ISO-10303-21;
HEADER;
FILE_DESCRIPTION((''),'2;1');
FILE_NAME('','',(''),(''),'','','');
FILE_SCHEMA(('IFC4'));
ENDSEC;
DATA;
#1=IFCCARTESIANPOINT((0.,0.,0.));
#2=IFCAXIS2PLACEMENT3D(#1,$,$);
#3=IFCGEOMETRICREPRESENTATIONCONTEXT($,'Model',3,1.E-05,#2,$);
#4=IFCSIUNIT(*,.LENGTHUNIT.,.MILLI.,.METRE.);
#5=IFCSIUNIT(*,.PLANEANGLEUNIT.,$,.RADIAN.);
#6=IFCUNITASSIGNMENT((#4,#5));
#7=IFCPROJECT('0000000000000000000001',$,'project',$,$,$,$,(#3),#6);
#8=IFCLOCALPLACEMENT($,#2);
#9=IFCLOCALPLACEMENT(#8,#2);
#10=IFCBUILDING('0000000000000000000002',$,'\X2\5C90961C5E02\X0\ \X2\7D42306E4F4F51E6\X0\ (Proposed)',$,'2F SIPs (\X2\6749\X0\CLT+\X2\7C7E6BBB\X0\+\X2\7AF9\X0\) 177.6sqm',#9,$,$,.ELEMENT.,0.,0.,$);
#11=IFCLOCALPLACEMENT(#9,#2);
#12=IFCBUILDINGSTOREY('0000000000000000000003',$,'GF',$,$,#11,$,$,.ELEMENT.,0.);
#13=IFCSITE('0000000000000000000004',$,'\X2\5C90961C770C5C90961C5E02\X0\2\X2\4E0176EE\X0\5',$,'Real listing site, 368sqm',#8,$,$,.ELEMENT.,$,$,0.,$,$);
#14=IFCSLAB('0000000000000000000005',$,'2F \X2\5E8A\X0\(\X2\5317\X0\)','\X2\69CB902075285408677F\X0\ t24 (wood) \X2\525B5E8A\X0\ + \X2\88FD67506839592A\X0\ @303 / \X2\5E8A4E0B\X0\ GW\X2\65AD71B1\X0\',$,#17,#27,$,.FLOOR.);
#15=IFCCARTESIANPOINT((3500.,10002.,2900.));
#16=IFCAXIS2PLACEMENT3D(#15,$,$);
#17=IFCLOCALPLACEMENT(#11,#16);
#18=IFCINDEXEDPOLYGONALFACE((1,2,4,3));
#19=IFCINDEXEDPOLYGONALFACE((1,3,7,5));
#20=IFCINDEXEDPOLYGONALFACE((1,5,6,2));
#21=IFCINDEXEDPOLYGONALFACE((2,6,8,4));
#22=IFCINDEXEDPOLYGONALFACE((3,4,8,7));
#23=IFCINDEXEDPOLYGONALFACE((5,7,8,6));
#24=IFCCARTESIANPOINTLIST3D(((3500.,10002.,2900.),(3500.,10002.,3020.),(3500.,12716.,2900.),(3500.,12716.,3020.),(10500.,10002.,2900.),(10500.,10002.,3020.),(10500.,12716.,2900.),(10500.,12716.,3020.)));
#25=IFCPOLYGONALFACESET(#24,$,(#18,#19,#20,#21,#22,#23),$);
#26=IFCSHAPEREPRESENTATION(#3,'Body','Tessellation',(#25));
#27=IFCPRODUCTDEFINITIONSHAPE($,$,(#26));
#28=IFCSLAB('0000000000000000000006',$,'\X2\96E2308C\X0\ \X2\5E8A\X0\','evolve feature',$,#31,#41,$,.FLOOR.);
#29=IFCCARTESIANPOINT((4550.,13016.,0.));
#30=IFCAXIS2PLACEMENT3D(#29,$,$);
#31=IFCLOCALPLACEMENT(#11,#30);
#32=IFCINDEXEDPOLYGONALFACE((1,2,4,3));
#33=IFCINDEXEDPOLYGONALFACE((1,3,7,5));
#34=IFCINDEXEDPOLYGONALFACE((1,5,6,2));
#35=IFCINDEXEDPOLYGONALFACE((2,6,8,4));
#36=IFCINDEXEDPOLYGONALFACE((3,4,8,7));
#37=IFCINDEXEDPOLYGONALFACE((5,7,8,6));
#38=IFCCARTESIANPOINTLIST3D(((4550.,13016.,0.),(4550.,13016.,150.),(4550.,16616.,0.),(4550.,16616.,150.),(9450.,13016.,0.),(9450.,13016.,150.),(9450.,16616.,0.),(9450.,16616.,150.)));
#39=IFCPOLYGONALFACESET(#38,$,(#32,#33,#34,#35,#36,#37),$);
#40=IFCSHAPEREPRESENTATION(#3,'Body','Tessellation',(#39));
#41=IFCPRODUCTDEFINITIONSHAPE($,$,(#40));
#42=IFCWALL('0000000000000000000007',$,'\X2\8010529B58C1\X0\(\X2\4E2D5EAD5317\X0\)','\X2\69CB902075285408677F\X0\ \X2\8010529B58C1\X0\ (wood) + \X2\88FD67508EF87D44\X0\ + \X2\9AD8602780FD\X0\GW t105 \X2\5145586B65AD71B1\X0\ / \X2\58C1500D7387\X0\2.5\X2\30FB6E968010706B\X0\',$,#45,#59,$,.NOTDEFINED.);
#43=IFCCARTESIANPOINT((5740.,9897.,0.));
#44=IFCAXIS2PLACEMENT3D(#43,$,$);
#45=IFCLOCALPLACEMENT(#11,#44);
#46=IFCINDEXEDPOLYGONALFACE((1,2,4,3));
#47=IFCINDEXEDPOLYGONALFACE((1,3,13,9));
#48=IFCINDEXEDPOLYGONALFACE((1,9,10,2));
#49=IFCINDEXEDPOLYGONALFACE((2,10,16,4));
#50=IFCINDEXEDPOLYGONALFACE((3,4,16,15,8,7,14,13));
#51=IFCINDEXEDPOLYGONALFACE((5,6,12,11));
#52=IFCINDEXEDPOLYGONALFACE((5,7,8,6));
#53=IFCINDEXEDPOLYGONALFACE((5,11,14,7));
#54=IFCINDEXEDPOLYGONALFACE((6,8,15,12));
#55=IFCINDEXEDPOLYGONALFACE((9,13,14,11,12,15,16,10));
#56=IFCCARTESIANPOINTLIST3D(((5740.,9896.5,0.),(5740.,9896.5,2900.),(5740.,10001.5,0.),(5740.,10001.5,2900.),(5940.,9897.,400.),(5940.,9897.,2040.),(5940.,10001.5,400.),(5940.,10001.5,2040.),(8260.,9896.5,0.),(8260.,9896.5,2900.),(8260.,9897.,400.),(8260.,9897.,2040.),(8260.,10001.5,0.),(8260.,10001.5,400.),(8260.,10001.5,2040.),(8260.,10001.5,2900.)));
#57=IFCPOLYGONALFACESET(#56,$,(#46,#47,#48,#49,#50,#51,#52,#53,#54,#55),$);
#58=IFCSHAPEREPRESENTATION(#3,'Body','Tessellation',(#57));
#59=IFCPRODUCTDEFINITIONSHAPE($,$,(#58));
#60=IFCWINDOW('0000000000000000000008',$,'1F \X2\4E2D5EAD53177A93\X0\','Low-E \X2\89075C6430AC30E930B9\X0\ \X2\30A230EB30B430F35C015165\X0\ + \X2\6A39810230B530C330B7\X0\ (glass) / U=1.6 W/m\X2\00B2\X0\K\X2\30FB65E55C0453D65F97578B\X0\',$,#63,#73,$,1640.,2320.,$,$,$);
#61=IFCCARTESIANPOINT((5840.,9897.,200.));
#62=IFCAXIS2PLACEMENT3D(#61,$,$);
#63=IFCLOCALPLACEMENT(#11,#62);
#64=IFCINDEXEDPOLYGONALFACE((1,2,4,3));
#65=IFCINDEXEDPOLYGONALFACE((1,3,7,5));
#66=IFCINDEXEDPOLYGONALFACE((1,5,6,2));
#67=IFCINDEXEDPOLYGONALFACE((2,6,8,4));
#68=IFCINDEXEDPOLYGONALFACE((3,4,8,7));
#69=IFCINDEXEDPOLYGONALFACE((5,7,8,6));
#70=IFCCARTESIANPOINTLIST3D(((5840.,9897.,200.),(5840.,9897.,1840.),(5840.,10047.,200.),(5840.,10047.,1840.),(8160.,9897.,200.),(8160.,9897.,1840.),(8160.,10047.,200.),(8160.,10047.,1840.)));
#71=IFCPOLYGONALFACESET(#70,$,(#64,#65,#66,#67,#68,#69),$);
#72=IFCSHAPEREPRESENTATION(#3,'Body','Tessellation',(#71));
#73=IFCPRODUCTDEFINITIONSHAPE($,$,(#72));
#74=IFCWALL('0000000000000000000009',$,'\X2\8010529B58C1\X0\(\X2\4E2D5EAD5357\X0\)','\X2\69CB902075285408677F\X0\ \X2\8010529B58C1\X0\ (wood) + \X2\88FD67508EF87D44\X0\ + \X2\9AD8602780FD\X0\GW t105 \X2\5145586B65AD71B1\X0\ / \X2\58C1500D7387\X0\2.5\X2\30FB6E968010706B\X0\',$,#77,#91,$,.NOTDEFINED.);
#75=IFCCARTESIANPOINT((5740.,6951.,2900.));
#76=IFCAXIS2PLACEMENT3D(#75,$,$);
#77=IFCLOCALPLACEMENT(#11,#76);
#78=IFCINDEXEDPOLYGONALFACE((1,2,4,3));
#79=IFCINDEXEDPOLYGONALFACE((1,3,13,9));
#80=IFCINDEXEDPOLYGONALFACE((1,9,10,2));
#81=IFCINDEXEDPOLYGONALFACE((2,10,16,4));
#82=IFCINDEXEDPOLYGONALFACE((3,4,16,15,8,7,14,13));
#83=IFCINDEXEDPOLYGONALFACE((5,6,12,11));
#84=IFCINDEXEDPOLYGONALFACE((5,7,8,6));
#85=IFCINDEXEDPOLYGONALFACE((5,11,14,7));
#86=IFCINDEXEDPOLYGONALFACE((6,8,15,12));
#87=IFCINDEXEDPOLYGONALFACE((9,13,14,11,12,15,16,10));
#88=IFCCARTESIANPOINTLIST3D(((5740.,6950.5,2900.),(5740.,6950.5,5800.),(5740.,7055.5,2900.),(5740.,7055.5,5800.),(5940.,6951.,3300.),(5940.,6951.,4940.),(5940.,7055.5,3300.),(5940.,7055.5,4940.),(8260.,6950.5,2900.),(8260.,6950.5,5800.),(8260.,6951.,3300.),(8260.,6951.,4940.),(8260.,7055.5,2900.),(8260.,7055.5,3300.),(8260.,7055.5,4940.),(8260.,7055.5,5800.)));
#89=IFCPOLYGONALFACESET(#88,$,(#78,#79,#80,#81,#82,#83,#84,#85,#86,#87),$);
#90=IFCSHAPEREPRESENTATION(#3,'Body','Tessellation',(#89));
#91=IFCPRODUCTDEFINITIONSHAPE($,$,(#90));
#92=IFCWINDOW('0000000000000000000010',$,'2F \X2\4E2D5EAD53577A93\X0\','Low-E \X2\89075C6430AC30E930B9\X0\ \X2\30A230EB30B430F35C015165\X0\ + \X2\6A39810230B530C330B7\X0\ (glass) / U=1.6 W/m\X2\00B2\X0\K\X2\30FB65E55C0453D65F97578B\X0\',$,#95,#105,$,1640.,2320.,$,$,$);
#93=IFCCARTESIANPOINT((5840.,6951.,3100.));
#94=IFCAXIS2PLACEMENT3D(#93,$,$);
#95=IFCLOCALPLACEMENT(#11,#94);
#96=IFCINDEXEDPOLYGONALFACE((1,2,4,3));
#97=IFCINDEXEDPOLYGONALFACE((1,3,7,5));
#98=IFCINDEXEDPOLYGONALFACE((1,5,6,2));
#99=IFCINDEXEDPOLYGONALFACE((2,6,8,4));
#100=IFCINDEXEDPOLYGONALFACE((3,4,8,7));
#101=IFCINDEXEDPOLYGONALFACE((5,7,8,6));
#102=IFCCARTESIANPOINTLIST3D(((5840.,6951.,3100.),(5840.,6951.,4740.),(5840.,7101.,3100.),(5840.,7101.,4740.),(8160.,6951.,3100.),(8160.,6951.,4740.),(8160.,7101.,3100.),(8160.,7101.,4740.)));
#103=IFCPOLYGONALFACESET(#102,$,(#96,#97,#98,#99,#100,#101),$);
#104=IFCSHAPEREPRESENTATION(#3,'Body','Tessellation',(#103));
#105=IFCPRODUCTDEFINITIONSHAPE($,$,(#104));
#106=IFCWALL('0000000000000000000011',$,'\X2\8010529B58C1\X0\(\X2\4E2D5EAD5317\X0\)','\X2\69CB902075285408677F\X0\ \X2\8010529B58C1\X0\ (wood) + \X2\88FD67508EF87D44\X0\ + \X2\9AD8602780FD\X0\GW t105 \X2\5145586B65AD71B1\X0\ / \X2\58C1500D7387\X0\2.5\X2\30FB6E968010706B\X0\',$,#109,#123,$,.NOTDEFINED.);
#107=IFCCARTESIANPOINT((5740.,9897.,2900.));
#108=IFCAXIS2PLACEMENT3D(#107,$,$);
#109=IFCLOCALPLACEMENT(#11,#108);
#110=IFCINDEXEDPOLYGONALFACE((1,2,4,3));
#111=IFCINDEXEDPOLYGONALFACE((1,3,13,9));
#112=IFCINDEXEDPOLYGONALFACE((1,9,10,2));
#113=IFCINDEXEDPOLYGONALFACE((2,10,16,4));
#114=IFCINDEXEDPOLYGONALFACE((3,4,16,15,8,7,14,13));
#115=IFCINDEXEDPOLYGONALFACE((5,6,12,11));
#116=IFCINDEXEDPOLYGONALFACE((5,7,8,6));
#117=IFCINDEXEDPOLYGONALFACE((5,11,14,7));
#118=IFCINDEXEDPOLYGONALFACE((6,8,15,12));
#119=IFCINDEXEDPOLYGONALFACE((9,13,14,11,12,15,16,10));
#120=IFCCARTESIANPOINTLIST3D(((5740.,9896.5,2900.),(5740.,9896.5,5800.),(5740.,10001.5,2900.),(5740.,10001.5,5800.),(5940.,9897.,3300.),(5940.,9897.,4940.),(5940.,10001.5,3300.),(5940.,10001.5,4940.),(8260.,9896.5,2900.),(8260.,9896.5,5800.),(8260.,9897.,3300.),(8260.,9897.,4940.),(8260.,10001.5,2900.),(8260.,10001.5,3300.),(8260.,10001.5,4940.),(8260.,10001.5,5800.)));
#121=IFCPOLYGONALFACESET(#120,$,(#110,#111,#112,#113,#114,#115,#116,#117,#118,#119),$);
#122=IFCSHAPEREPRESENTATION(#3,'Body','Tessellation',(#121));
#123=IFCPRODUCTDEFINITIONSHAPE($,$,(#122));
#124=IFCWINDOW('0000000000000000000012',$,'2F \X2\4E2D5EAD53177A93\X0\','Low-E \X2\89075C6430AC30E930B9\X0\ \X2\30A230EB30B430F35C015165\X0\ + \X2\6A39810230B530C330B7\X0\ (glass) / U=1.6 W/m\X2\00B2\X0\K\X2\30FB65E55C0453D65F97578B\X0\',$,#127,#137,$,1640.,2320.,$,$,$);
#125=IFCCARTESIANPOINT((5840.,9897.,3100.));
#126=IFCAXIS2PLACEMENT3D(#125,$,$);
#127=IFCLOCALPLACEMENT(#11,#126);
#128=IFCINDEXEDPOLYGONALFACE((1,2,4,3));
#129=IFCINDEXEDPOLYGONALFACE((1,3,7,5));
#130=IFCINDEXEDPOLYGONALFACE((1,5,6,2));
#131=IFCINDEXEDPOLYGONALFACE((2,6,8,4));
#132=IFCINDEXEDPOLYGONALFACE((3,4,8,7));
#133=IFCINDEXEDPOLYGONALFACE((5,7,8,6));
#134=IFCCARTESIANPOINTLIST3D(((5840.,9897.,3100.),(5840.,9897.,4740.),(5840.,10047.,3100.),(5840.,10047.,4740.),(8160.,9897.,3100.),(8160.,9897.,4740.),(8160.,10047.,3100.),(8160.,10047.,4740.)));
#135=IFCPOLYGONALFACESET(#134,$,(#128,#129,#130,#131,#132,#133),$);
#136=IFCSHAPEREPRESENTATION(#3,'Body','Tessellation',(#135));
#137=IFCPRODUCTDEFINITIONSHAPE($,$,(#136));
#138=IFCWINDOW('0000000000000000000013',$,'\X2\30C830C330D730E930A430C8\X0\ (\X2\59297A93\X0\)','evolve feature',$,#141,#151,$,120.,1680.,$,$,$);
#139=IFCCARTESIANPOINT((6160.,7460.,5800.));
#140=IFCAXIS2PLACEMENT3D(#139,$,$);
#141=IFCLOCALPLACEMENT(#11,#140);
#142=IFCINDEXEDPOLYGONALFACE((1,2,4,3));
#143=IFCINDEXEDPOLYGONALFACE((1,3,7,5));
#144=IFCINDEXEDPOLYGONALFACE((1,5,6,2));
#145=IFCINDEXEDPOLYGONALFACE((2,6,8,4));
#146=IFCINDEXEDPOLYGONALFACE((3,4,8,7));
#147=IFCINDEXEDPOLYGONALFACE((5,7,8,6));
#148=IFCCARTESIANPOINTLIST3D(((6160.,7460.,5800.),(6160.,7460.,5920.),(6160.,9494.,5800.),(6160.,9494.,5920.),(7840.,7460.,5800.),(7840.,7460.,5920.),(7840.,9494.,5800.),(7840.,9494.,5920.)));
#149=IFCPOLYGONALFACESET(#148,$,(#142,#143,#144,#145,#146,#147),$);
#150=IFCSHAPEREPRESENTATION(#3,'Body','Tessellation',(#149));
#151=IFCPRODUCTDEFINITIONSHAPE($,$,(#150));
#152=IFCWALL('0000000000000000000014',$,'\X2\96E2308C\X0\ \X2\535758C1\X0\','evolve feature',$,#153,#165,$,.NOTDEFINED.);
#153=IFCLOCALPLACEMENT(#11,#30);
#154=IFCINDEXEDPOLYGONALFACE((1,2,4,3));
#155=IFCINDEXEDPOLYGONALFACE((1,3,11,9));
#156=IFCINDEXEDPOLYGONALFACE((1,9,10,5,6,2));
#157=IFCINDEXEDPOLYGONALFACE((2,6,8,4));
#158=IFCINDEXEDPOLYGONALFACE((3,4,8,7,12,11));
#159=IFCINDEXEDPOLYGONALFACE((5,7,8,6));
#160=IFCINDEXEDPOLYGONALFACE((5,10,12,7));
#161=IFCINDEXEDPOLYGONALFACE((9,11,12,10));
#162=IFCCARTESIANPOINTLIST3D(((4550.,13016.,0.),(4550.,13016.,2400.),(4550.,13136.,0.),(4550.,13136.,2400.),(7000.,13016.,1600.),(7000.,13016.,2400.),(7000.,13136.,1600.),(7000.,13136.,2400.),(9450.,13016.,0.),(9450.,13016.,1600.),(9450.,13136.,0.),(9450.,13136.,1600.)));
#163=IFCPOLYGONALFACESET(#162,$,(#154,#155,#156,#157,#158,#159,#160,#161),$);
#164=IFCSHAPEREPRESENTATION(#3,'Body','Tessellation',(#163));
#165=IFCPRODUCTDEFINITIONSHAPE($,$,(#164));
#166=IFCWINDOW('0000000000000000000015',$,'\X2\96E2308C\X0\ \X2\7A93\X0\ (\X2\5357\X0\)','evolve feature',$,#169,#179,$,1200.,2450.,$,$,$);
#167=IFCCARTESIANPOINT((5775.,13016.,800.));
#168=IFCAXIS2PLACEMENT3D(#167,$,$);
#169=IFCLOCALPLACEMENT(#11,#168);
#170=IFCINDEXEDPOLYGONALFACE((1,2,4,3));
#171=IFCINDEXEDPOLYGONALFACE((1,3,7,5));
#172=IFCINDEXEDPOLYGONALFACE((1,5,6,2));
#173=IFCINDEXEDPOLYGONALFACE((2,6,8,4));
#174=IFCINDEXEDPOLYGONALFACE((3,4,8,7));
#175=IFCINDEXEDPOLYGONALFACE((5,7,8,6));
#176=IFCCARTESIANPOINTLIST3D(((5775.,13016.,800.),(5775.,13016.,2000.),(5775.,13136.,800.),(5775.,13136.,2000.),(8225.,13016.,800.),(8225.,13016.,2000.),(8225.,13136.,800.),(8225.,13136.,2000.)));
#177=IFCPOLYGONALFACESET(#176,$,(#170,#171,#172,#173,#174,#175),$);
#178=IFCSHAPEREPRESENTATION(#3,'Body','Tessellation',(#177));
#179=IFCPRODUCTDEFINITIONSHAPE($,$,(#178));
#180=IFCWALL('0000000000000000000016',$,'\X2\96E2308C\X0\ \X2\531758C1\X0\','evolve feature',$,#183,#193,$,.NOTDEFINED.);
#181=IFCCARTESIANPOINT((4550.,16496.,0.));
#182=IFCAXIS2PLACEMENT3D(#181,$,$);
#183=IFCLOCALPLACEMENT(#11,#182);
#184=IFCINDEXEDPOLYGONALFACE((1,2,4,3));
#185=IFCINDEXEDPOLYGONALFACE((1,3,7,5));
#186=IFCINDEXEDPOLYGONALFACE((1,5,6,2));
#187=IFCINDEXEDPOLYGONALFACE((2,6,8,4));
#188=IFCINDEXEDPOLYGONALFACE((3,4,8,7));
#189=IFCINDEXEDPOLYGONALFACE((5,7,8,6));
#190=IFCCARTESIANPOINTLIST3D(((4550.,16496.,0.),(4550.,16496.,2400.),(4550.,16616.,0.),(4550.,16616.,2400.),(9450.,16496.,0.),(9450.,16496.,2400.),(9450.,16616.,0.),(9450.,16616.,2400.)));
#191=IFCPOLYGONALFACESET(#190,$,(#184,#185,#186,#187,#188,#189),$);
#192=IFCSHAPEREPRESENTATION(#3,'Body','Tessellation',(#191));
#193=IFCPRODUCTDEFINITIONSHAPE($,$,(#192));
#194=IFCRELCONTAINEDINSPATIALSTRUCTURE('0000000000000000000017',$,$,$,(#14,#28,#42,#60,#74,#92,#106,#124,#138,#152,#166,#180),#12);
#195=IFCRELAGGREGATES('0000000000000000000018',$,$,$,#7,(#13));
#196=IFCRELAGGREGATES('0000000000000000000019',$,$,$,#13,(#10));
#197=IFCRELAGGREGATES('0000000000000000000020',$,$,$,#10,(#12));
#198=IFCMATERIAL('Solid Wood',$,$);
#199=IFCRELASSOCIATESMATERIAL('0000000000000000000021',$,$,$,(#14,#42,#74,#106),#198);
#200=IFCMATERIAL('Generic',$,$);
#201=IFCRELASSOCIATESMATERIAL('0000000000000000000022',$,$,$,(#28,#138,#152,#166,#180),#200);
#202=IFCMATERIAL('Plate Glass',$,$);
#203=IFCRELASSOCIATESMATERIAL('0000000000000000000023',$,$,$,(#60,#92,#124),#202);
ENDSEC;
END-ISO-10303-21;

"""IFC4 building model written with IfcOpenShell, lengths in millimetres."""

from ifc_helpers import new_model, si_unit, frame, frame_2d, origin, place, context, project, spatial, rectangle, extrude, material, element, fill, save


model = new_model("IFC4")

# Units and contexts
model_context = context("Model", 3, precision=1e-05, world=origin())
ifc_project = project(units=[si_unit("LENGTHUNIT", "METRE", prefix="MILLI"), si_unit("PLANEANGLEUNIT", "RADIAN")], contexts=[model_context])

# Site, building, storey
site_placement = place(None, origin())
site = spatial("IfcSite", under=ifc_project, at=site_placement, Name="岐阜県岐阜市2丁目5", ObjectType="Real listing site, 368sqm", CompositionType="ELEMENT", RefElevation=0.0)
building_placement = place(site_placement, origin())
building = spatial("IfcBuilding", under=site, at=building_placement, Name="岐阜市 終の住処 (Proposed)", ObjectType="2F SIPs (杉CLT+籾殻+竹) 177.6sqm", CompositionType="ELEMENT", ElevationOfRefHeight=0.0, ElevationOfTerrain=0.0)
storey_placement = place(building_placement, origin())
storey = spatial("IfcBuildingStorey", under=building, at=storey_placement, Name="GF", CompositionType="ELEMENT", Elevation=0.0)

# Slabs
ifc_material_1 = material(Name="Solid Wood")
slab_1_placement = place(storey_placement, frame((3500.0, 10002.0, 2900.0)))
element("IfcSlab", 1, at=slab_1_placement, inside=storey, material=ifc_material_1, Name="2F 床(北)", Description="構造用合板 t24 (wood) 剛床 + 製材根太 @303 / 床下 GW断熱", PredefinedType="FLOOR", context=model_context, shape_type="SweptSolid", body=[
    extrude(rectangle(XDim=7000.0, YDim=2714.0, at=frame_2d((3500.0, 1357.0))), frame((3500.0, 10002.0, 2900.0)), (0.0, 0.0, 1.0), 120.0),
])
ifc_material_2 = material(Name="Generic")
slab_2_placement = place(storey_placement, frame((4550.0, 13016.0, 0.0)))
element("IfcSlab", 2, at=slab_2_placement, inside=storey, material=ifc_material_2, Name="離れ 床", Description="evolve feature", PredefinedType="FLOOR", context=model_context, shape_type="SweptSolid", body=[
    extrude(rectangle(XDim=4900.0, YDim=3600.0, at=frame_2d((2450.0, 1800.0))), frame((4550.0, 13016.0, 0.0)), (0.0, 0.0, 1.0), 150.0),
])

# Wall, opening, window
wall_1_placement = place(storey_placement, frame((5740.0, 9897.0, 0.0)))
wall_1 = element("IfcWall", 3, at=wall_1_placement, inside=storey, material=ifc_material_1, Name="耐力壁(中庭北)", Description="構造用合板 耐力壁 (wood) + 製材軸組 + 高性能GW t105 充填断熱 / 壁倍率2.5・準耐火", PredefinedType="NOTDEFINED", context=model_context, shape_type="SweptSolid", body=[
    extrude(rectangle(XDim=2520.0, YDim=105.0, at=frame_2d((1260.0, 52.0))), frame((5740.0, 9897.0, 0.0)), (0.0, 0.0, 1.0), 2900.0),
])
opening_1_placement = place(storey_placement, frame((5840.0, 9897.0, 200.0)))
opening_1 = element("IfcOpeningElement", 4, at=opening_1_placement, cuts=wall_1, PredefinedType="NOTDEFINED", context=model_context, shape_type="SweptSolid", body=[
    extrude(rectangle(XDim=2320.0, YDim=150.0, at=frame_2d((1160.0, 75.0))), frame((5840.0, 9897.0, 200.0)), (0.0, 0.0, 1.0), 1640.0),
])
ifc_material_3 = material(Name="Plate Glass")
window_1_placement = place(storey_placement, frame((5840.0, 9897.0, 200.0)))
window_1 = element("IfcWindow", 5, at=window_1_placement, inside=storey, material=ifc_material_3, Name="1F 中庭北窓", Description="Low-E 複層ガラス アルゴン封入 + 樹脂サッシ (glass) / U=1.6 W/m²K・日射取得型", OverallHeight=1640.0, OverallWidth=2320.0, context=model_context, shape_type="SweptSolid", body=[
    extrude(rectangle(XDim=2320.0, YDim=150.0, at=frame_2d((1160.0, 75.0))), frame((5840.0, 9897.0, 200.0)), (0.0, 0.0, 1.0), 1640.0),
])
fill(opening_1, window_1)

# Walls, openings, windows
wall_2_placement = place(storey_placement, frame((5740.0, 6951.0, 2900.0)))
wall_2 = element("IfcWall", 6, at=wall_2_placement, inside=storey, material=ifc_material_1, Name="耐力壁(中庭南)", Description="構造用合板 耐力壁 (wood) + 製材軸組 + 高性能GW t105 充填断熱 / 壁倍率2.5・準耐火", PredefinedType="NOTDEFINED", context=model_context, shape_type="SweptSolid", body=[
    extrude(rectangle(XDim=2520.0, YDim=105.0, at=frame_2d((1260.0, 52.0))), frame((5740.0, 6951.0, 2900.0)), (0.0, 0.0, 1.0), 2900.0),
])
opening_2_placement = place(storey_placement, frame((5840.0, 6951.0, 3100.0)))
opening_2 = element("IfcOpeningElement", 7, at=opening_2_placement, cuts=wall_2, PredefinedType="NOTDEFINED", context=model_context, shape_type="SweptSolid", body=[
    extrude(rectangle(XDim=2320.0, YDim=150.0, at=frame_2d((1160.0, 75.0))), frame((5840.0, 6951.0, 3100.0)), (0.0, 0.0, 1.0), 1640.0),
])
window_2_placement = place(storey_placement, frame((5840.0, 6951.0, 3100.0)))
window_2 = element("IfcWindow", 8, at=window_2_placement, inside=storey, material=ifc_material_3, Name="2F 中庭南窓", Description="Low-E 複層ガラス アルゴン封入 + 樹脂サッシ (glass) / U=1.6 W/m²K・日射取得型", OverallHeight=1640.0, OverallWidth=2320.0, context=model_context, shape_type="SweptSolid", body=[
    extrude(rectangle(XDim=2320.0, YDim=150.0, at=frame_2d((1160.0, 75.0))), frame((5840.0, 6951.0, 3100.0)), (0.0, 0.0, 1.0), 1640.0),
])
fill(opening_2, window_2)
wall_3_placement = place(storey_placement, frame((5740.0, 9897.0, 2900.0)))
wall_3 = element("IfcWall", 9, at=wall_3_placement, inside=storey, material=ifc_material_1, Name="耐力壁(中庭北)", Description="構造用合板 耐力壁 (wood) + 製材軸組 + 高性能GW t105 充填断熱 / 壁倍率2.5・準耐火", PredefinedType="NOTDEFINED", context=model_context, shape_type="SweptSolid", body=[
    extrude(rectangle(XDim=2520.0, YDim=105.0, at=frame_2d((1260.0, 52.0))), frame((5740.0, 9897.0, 2900.0)), (0.0, 0.0, 1.0), 2900.0),
])
opening_3_placement = place(storey_placement, frame((5840.0, 9897.0, 3100.0)))
opening_3 = element("IfcOpeningElement", 10, at=opening_3_placement, cuts=wall_3, PredefinedType="NOTDEFINED", context=model_context, shape_type="SweptSolid", body=[
    extrude(rectangle(XDim=2320.0, YDim=150.0, at=frame_2d((1160.0, 75.0))), frame((5840.0, 9897.0, 3100.0)), (0.0, 0.0, 1.0), 1640.0),
])
window_3_placement = place(storey_placement, frame((5840.0, 9897.0, 3100.0)))
window_3 = element("IfcWindow", 11, at=window_3_placement, inside=storey, material=ifc_material_3, Name="2F 中庭北窓", Description="Low-E 複層ガラス アルゴン封入 + 樹脂サッシ (glass) / U=1.6 W/m²K・日射取得型", OverallHeight=1640.0, OverallWidth=2320.0, context=model_context, shape_type="SweptSolid", body=[
    extrude(rectangle(XDim=2320.0, YDim=150.0, at=frame_2d((1160.0, 75.0))), frame((5840.0, 9897.0, 3100.0)), (0.0, 0.0, 1.0), 1640.0),
])
fill(opening_3, window_3)

# Window
window_4_placement = place(storey_placement, frame((6160.0, 7460.0, 5800.0)))
element("IfcWindow", 12, at=window_4_placement, inside=storey, material=ifc_material_2, Name="トップライト (天窓)", Description="evolve feature", OverallHeight=120.0, OverallWidth=1680.0, context=model_context, shape_type="SweptSolid", body=[
    extrude(rectangle(XDim=1680.0, YDim=2034.0, at=frame_2d((840.0, 1017.0))), frame((6160.0, 7460.0, 5800.0)), (0.0, 0.0, 1.0), 120.0),
])

# Wall, opening, window
wall_4_placement = place(storey_placement, frame((4550.0, 13016.0, 0.0)))
wall_4 = element("IfcWall", 13, at=wall_4_placement, inside=storey, material=ifc_material_2, Name="離れ 南壁", Description="evolve feature", PredefinedType="NOTDEFINED", context=model_context, shape_type="SweptSolid", body=[
    extrude(rectangle(XDim=4900.0, YDim=120.0, at=frame_2d((2450.0, 60.0))), frame((4550.0, 13016.0, 0.0)), (0.0, 0.0, 1.0), 2400.0),
])
opening_4_placement = place(storey_placement, frame((5775.0, 13016.0, 800.0)))
opening_4 = element("IfcOpeningElement", 14, at=opening_4_placement, cuts=wall_4, PredefinedType="NOTDEFINED", context=model_context, shape_type="SweptSolid", body=[
    extrude(rectangle(XDim=2450.0, YDim=120.0, at=frame_2d((1225.0, 60.0))), frame((5775.0, 13016.0, 800.0)), (0.0, 0.0, 1.0), 1200.0),
])
window_5_placement = place(storey_placement, frame((5775.0, 13016.0, 800.0)))
window_5 = element("IfcWindow", 15, at=window_5_placement, inside=storey, material=ifc_material_2, Name="離れ 窓 (南)", Description="evolve feature", OverallHeight=1200.0, OverallWidth=2450.0, context=model_context, shape_type="SweptSolid", body=[
    extrude(rectangle(XDim=2450.0, YDim=120.0, at=frame_2d((1225.0, 60.0))), frame((5775.0, 13016.0, 800.0)), (0.0, 0.0, 1.0), 1200.0),
])
fill(opening_4, window_5)

# Wall
wall_5_placement = place(storey_placement, frame((4550.0, 16496.0, 0.0)))
element("IfcWall", 16, at=wall_5_placement, inside=storey, material=ifc_material_2, Name="離れ 北壁", Description="evolve feature", PredefinedType="NOTDEFINED", context=model_context, shape_type="SweptSolid", body=[
    extrude(rectangle(XDim=4900.0, YDim=120.0, at=frame_2d((2450.0, 60.0))), frame((4550.0, 16496.0, 0.0)), (0.0, 0.0, 1.0), 2400.0),
])

save(model, "model.ifc")
